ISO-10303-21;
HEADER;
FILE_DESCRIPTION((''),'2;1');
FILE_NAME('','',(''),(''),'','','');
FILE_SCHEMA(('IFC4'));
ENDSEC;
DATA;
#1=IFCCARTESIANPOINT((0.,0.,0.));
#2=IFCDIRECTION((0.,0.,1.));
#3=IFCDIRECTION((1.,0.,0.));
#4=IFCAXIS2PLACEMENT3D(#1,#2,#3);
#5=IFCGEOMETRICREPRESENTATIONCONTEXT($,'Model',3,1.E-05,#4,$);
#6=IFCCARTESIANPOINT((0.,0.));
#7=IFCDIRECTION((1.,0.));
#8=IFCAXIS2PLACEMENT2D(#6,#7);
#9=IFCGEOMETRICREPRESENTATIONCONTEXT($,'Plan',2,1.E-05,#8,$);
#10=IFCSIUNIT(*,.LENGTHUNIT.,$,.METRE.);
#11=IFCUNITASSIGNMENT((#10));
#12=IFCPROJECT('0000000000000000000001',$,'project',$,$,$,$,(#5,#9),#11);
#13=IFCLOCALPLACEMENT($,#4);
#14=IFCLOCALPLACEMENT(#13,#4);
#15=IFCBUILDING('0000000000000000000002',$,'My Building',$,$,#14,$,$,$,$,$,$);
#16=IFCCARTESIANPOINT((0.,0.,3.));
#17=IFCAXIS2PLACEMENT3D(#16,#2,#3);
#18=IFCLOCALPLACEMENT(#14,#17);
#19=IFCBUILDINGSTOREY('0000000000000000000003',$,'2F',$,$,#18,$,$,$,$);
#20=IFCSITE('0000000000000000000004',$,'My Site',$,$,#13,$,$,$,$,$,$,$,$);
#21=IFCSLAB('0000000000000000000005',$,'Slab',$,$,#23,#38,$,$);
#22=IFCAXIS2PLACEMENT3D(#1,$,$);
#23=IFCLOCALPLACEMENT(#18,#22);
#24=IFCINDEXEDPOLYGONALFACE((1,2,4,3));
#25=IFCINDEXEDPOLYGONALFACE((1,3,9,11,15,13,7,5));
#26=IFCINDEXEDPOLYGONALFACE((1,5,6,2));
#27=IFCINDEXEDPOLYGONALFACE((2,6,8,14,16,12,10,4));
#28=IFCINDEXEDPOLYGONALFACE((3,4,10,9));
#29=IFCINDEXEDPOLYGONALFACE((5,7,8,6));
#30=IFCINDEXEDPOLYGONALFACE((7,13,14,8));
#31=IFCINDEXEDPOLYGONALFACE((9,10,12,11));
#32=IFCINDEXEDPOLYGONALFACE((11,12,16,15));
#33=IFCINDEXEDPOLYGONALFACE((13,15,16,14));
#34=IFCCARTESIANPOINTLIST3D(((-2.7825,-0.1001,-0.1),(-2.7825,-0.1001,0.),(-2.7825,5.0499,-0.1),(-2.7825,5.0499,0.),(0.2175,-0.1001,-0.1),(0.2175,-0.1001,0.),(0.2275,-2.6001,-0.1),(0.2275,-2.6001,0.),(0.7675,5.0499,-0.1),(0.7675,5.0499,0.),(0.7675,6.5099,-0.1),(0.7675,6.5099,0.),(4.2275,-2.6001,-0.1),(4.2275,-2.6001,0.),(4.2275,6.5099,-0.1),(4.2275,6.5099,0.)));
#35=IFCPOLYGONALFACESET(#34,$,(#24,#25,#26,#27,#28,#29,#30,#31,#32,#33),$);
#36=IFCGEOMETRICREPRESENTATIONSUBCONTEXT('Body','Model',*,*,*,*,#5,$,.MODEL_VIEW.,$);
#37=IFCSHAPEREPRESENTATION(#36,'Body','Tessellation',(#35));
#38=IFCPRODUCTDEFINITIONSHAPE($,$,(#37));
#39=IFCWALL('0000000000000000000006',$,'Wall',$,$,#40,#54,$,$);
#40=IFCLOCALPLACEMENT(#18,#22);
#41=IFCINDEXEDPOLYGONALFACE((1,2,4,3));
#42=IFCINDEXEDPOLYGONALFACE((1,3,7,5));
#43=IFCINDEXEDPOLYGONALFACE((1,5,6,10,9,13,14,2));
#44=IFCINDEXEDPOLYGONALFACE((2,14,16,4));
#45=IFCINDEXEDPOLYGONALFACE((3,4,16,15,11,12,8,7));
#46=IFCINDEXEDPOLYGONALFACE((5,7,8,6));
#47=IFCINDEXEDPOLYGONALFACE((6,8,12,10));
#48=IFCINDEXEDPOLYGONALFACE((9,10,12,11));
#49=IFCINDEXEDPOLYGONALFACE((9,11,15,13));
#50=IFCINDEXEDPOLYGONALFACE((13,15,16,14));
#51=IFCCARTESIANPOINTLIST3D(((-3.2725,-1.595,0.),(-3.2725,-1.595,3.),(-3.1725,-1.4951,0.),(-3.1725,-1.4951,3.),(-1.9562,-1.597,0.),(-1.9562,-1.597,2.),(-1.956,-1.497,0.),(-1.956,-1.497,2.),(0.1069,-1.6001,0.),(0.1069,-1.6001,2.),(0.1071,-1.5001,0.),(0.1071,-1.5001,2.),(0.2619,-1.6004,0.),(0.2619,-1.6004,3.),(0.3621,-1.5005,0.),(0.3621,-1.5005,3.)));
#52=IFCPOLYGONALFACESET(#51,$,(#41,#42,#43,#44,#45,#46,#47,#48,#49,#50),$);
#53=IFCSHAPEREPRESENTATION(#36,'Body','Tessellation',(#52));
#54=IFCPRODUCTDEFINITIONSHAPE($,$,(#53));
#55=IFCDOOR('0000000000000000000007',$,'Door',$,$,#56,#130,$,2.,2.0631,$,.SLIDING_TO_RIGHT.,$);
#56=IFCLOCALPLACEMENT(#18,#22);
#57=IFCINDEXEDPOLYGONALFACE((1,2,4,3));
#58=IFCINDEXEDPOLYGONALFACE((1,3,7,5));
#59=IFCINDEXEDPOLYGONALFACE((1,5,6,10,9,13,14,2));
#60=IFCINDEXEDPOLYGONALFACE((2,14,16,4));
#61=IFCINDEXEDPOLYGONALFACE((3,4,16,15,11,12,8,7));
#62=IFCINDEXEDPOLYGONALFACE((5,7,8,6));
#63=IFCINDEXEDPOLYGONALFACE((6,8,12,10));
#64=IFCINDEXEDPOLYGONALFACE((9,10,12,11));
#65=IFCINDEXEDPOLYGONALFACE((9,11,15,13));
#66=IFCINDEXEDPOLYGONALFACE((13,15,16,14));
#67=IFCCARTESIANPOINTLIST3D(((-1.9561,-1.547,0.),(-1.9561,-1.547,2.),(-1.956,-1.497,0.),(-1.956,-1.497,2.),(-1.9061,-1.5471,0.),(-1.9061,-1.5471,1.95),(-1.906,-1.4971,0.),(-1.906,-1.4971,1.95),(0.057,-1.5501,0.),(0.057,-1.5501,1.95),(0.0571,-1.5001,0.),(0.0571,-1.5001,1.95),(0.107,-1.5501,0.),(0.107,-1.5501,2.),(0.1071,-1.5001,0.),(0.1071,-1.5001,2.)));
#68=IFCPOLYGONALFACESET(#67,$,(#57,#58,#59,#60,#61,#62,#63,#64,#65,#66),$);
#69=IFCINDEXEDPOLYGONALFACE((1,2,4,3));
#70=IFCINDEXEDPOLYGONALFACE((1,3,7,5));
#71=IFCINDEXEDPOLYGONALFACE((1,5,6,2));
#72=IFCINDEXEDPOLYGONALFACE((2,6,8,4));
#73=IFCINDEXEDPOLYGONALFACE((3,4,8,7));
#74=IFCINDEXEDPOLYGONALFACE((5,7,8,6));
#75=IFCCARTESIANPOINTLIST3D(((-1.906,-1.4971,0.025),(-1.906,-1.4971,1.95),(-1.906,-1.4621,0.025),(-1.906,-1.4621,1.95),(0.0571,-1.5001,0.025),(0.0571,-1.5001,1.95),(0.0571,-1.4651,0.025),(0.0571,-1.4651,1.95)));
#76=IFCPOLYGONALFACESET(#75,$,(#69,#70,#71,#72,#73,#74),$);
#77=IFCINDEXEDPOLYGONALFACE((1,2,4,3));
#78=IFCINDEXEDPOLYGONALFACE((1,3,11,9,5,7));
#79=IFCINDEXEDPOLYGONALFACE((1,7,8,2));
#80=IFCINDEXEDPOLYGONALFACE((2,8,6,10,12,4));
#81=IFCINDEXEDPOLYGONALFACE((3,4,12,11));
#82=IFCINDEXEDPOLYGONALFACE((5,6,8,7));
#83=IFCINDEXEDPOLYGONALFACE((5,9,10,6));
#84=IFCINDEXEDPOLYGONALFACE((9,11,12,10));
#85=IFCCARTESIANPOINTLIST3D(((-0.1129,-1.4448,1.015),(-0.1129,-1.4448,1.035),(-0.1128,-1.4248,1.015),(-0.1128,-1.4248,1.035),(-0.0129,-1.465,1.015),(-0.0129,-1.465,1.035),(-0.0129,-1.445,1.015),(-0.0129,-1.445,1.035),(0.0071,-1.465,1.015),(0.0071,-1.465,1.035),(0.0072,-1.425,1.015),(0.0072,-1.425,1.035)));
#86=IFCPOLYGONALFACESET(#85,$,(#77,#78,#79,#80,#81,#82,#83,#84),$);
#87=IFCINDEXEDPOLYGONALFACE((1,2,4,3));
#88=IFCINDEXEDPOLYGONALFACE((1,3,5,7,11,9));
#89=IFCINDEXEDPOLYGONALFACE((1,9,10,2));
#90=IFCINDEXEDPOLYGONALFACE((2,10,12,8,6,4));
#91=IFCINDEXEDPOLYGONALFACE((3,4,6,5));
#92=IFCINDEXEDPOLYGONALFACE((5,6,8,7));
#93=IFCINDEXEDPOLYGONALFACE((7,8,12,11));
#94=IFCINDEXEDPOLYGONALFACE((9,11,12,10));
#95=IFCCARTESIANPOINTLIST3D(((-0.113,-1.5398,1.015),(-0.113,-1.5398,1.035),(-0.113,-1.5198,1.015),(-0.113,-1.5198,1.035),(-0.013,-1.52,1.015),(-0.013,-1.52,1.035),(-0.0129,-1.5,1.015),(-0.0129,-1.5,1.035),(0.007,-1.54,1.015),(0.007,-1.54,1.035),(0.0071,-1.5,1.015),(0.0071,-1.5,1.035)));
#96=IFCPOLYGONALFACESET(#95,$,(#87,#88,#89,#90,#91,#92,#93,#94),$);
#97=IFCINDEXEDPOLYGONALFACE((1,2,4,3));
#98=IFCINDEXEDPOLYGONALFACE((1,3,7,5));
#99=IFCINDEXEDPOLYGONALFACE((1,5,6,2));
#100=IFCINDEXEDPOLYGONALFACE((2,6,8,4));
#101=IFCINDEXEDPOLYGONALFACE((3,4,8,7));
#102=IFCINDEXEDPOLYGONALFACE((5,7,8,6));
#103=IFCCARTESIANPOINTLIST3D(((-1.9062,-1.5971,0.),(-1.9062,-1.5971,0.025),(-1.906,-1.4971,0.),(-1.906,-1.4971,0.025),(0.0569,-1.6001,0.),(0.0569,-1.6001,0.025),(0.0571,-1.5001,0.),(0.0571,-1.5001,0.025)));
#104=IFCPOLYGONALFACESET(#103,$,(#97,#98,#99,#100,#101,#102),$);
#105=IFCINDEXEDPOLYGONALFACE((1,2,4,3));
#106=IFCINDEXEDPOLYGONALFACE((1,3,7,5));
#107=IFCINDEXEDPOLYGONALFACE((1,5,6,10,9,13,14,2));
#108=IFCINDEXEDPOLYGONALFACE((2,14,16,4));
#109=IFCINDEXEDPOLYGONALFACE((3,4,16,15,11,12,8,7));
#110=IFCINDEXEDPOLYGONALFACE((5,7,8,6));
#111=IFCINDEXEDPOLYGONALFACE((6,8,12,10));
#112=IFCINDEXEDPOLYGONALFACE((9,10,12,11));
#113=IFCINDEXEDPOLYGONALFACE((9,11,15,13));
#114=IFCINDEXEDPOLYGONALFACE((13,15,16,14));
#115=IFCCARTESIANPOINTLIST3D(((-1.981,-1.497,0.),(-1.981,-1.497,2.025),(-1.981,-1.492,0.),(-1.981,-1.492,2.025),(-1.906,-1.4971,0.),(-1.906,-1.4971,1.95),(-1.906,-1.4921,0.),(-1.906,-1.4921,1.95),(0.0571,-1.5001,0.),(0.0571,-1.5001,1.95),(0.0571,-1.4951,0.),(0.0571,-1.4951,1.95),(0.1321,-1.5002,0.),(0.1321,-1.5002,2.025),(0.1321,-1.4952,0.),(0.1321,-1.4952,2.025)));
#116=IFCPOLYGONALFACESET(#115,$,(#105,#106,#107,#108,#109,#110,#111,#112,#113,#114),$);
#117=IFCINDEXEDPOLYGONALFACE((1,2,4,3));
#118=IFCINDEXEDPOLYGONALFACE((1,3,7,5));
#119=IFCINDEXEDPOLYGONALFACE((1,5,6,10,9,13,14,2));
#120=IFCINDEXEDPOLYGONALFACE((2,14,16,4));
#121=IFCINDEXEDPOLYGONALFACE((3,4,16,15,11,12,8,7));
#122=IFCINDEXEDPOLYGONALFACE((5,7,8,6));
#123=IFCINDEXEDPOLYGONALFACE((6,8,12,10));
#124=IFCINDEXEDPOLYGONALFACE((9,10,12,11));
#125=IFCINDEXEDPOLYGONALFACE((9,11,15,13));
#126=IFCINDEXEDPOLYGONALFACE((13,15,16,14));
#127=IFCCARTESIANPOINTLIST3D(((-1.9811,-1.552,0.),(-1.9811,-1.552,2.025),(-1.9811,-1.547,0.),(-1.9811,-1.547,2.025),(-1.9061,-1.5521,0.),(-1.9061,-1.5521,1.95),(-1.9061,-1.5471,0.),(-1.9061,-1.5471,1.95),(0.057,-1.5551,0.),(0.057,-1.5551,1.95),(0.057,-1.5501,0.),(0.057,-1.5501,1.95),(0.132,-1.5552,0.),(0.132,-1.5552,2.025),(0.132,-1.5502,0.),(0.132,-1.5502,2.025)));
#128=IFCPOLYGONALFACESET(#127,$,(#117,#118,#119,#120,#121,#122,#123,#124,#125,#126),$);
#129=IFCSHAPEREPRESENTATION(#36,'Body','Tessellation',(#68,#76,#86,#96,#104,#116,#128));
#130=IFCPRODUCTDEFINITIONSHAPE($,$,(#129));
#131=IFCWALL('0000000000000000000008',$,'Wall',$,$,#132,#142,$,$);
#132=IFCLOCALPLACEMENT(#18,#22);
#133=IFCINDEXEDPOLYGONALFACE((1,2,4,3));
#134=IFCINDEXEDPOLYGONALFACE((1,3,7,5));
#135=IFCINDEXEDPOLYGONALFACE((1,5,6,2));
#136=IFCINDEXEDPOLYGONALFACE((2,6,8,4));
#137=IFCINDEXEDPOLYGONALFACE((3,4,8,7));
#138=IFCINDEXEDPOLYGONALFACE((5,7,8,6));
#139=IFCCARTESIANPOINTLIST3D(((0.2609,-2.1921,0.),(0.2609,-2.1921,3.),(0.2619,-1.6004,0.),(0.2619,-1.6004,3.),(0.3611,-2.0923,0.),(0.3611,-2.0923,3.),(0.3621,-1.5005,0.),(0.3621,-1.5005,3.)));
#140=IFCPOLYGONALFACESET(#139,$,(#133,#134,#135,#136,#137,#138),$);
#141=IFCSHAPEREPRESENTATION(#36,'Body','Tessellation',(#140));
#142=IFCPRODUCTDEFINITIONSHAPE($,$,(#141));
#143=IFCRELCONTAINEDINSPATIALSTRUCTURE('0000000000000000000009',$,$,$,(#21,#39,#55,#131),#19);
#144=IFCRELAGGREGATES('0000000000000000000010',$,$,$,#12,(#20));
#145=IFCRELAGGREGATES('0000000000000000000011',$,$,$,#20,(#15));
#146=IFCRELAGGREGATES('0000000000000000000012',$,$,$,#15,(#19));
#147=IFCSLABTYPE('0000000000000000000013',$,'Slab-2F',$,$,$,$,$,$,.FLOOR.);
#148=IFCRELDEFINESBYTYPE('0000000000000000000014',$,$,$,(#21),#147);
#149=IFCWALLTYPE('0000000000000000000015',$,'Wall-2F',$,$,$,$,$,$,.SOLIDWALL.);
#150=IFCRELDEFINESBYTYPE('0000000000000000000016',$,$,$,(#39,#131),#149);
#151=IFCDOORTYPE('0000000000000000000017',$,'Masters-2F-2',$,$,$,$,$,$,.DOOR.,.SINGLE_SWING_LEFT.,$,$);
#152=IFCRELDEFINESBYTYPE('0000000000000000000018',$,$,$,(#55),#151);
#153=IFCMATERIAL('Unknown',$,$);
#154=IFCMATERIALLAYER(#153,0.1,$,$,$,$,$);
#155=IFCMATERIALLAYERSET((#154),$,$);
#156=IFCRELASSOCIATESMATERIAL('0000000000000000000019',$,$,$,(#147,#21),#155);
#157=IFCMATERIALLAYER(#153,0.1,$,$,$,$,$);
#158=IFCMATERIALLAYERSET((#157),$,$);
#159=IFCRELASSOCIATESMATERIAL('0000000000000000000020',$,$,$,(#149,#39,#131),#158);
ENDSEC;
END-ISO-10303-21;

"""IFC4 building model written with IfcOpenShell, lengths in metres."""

from ifc_helpers import new_model, entity, si_unit, frame, origin_with_axes, origin_2d_with_axis, place, context, subcontext, project, spatial, line, indexed_curve, outline, extrude, shape, source, transform, mapped, material, layer, layer_set, layer_usage, type_object, type_shapes, element, fill, save


model = new_model("IFC4")

# Units and contexts
model_context = context("Model", 3, precision=1e-05, world=origin_with_axes())
plan_context = context("Plan", 2, precision=1e-05, world=origin_2d_with_axis())
body_context_1 = subcontext(model_context, "Body", "Model", "MODEL_VIEW")
body_context_2 = subcontext(plan_context, "Body", "Plan", "PLAN_VIEW")
ifc_project = project(units=[si_unit("LENGTHUNIT", "METRE")], contexts=[model_context, plan_context])

# Site, building, storey
site_placement = place(None, origin_with_axes())
site = spatial("IfcSite", under=ifc_project, at=site_placement, Name="My Site")
building_placement = place(site_placement, origin_with_axes())
building = spatial("IfcBuilding", under=site, at=building_placement, Name="My Building")
storey_placement = place(building_placement, frame((0.0, 0.0, 3.0), z_axis=(0.0, 0.0, 1.0), x_axis=(1.0, 0.0, 0.0)))
storey = spatial("IfcBuildingStorey", under=building, at=storey_placement, Name="2F")

# Slab
ifc_material = material(Name="Unknown")
ifc_layer_1 = layer(ifc_material, 0.1)
ifc_layer_set_1 = layer_set([ifc_layer_1])
ifc_layer_usage_1 = layer_usage(ifc_layer_set_1, "AXIS3", "POSITIVE", -0.1)
slab_type = type_object("IfcSlabType", Name="Slab-2F", PredefinedType="FLOOR", material=ifc_layer_set_1)
slab_placement = place(storey_placement, frame((4.2275, -2.6001, 0.0), z_axis=(0.0, 0.0, 1.0), x_axis=(1.0, 0.0, 0.0)))
element("IfcSlab", 1, at=slab_placement, inside=storey, type_object=slab_type, material=ifc_layer_usage_1, Name="Slab", context=body_context_1, shape_type="SweptSolid", body=[
    extrude(outline(indexed_curve([(0.0, 0.0), (0.0, 9.11), (-3.46, 9.11), (-3.46, 7.65), (-7.01, 7.65), (-7.01, 2.5), (-4.01, 2.5), (-4.0, 0.0), (0.0, 0.0)])), frame((0.0, 0.0, -0.1), z_axis=(0.0, 0.0, 1.0), x_axis=(1.0, 0.0, 0.0)), (0.0, 0.0, 1.0), 0.1),
])

# Wall, opening, door
ifc_layer_2 = layer(ifc_material, 0.1)
ifc_layer_set_2 = layer_set([ifc_layer_2])
ifc_layer_usage_2 = layer_usage(ifc_layer_set_2, "AXIS2", "POSITIVE", 0.0)
wall_type = type_object("IfcWallType", Name="Wall-2F", PredefinedType="SOLIDWALL", material=ifc_layer_set_2)
wall_1_placement = place(storey_placement, frame((-3.2725, -1.595, 0.0), z_axis=(0.0, 0.0, 1.0), x_axis=(0.999999, -0.001525, 0.0)))
wall_1 = element("IfcWall", 2, at=wall_1_placement, inside=storey, type_object=wall_type, material=ifc_layer_usage_2, Name="Wall", context=body_context_1, shape_type="SweptSolid", body=[
    extrude(outline(indexed_curve([(0.0, 0.0), (0.0998, 0.1), (3.6345, 0.1), (3.5345, 0.0)], segments=[line(1, 2, 3, 4, 1)])), origin_with_axes(), (0.0, 0.0, 1.0), 3.0),
])
shared_shape_1 = source(origin_with_axes(), body_context_1, "Body", "SweptSolid", [
    extrude(outline(indexed_curve([(0.0, 0.0), (2.0631, 0.0), (2.0631, 2.0), (0.0, 2.0)], segments=[line(1, 2, 3, 4, 1)])), frame((0.0, -0.6, 0.0), z_axis=(0.0, -1.0, 0.0), x_axis=(1.0, 0.0, 0.0)), (0.0, 0.0, -1.0), 1.2),
])
opening_1_placement = place(wall_1_placement, frame((3.3794, 0.1, 0.0), z_axis=(0.0, 0.0, 1.0), x_axis=(-1.0, 0.0, 0.0)))
opening_1 = element("IfcOpeningElement", 3, at=opening_1_placement, cuts=wall_1, PredefinedType="OPENING", context=body_context_1, shape_type="MappedRepresentation", body=[
    mapped(shared_shape_1, transform((0.0, 0.0, 0.0), x_axis=(1.0, 0.0, 0.0), y_axis=(0.0, 1.0, 0.0), z_axis=(0.0, 0.0, 1.0), scale=1.0)),
])
door_type_1 = type_object("IfcDoorType", Name="Masters-2F-2", OperationType="SINGLE_SWING_LEFT", PredefinedType="DOOR")
shared_shape_2 = source(origin_with_axes(), body_context_1, "Body", "SweptSolid", [
    extrude(outline(indexed_curve([(0.0, 0.0), (0.0, 2.0), (2.0631, 2.0), (2.0631, 0.0), (2.0131, 0.0), (2.0131, 1.95), (0.05, 1.95), (0.05, 0.0)], segments=[line(1, 2, 3, 4, 5, 6, 7, 8, 1)])), frame((0.0, 0.0, 0.0), z_axis=(0.0, -1.0, 0.0), x_axis=(1.0, 0.0, 0.0)), (0.0, 0.0, -1.0), 0.05),
    extrude(outline(indexed_curve([(0.0, 0.0), (1.9631, 0.0), (1.9631, 0.035), (0.0, 0.035)], segments=[line(1, 2, 3, 4, 1)])), frame((0.05, -0.035, 0.025), z_axis=(0.0, 0.0, 1.0), x_axis=(1.0, 0.0, 0.0)), (0.0, 0.0, 1.0), 1.925),
    extrude(outline(indexed_curve([(0.0, 0.0), (0.0, -0.04), (0.12, -0.04), (0.12, -0.02), (0.02, -0.02), (0.02, 0.0)], segments=[line(1, 2, 3, 4, 5, 6, 1)])), frame((0.1, -0.035, 1.015), z_axis=(0.0, 0.0, 1.0), x_axis=(1.0, 0.0, 0.0)), (0.0, 0.0, 1.0), 0.02),
    extrude(outline(indexed_curve([(0.0, 0.0), (0.0, 0.04), (0.12, 0.04), (0.12, 0.02), (0.02, 0.02), (0.02, 0.0)], segments=[line(1, 2, 3, 4, 5, 6, 1)])), frame((0.1, 0.0, 1.015), z_axis=(0.0, 0.0, 1.0), x_axis=(1.0, 0.0, 0.0)), (0.0, 0.0, 1.0), 0.02),
    extrude(outline(indexed_curve([(0.0, 0.0), (1.9631, 0.0), (1.9631, 0.1), (0.0, 0.1)], segments=[line(1, 2, 3, 4, 1)])), frame((0.05, 0.0, 0.0), z_axis=(0.0, 0.0, 1.0), x_axis=(1.0, 0.0, 0.0)), (0.0, 0.0, 1.0), 0.025),
    extrude(outline(indexed_curve([(0.0, 0.0), (0.0, 2.025), (2.1131, 2.025), (2.1131, 0.0), (2.0381, 0.0), (2.0381, 1.95), (0.075, 1.95), (0.075, 0.0)], segments=[line(1, 2, 3, 4, 5, 6, 7, 8, 1)])), frame((-0.025, -0.005, 0.0), z_axis=(0.0, -1.0, 0.0), x_axis=(1.0, 0.0, 0.0)), (0.0, 0.0, -1.0), 0.005),
    extrude(outline(indexed_curve([(0.0, 0.0), (0.0, 2.025), (2.1131, 2.025), (2.1131, 0.0), (2.0381, 0.0), (2.0381, 1.95), (0.075, 1.95), (0.075, 0.0)], segments=[line(1, 2, 3, 4, 5, 6, 7, 8, 1)])), frame((-0.025, 0.05, 0.0), z_axis=(0.0, -1.0, 0.0), x_axis=(1.0, 0.0, 0.0)), (0.0, 0.0, -1.0), 0.005),
])
shared_shape_3 = source(origin_with_axes(), body_context_2, "Body", "Curve2D", [
    entity("IfcIndexedPolyCurve", entity("IfcCartesianPointList2D", [[0.0, 0.0], [0.05, 0.0], [0.05, 0.05], [0.0, 0.05]]), [entity("IfcLineIndex", [1, 2, 3, 4, 1])]),
    entity("IfcIndexedPolyCurve", entity("IfcCartesianPointList2D", [[2.0631, 0.0], [2.0131, 0.0], [2.0131, 0.05], [2.0631, 0.05]]), [entity("IfcLineIndex", [1, 2, 3, 4, 1])]),
    entity("IfcIndexedPolyCurve", entity("IfcCartesianPointList2D", [[2.9946, -0.035], [1.0315, -0.035], [1.0315, 0.0], [2.9946, 0.0]]), [entity("IfcLineIndex", [1, 2, 3, 4, 1])]),
])
type_shapes(door_type_1, [shared_shape_2, shared_shape_3])
door_1_placement = place(opening_1_placement, frame((0.0, 0.0, 0.0), z_axis=(0.0, 0.0, 1.0), x_axis=(1.0, 0.0, 0.0)))
door_1 = element("IfcDoor", 4, at=door_1_placement, inside=storey, type_object=door_type_1, Name="Door", OperationType="SLIDING_TO_RIGHT", OverallHeight=2.0, OverallWidth=2.0631, shapes=[
    shape(body_context_1, "Body", "MappedRepresentation", [mapped(shared_shape_2, transform((0.0, 0.0, 0.0), x_axis=(1.0, 0.0, 0.0), y_axis=(0.0, 1.0, 0.0), z_axis=(0.0, 0.0, 1.0), scale=1.0))]),
    shape(body_context_2, "Body", "MappedRepresentation", [mapped(shared_shape_3, transform((0.0, 0.0, 0.0), x_axis=(1.0, 0.0, 0.0), y_axis=(0.0, 1.0, 0.0), z_axis=(0.0, 0.0, 1.0), scale=1.0))]),
])
fill(opening_1, door_1)

# Wall
ifc_layer_usage_3 = layer_usage(ifc_layer_set_2, "AXIS2", "POSITIVE", 0.0)
wall_2_placement = place(storey_placement, frame((0.2619, -1.6004, 0.0), z_axis=(0.0, 0.0, 1.0), x_axis=(-0.001703, -0.999999, 0.0)))
element("IfcWall", 5, at=wall_2_placement, inside=storey, type_object=wall_type, material=ifc_layer_usage_3, Name="Wall", context=body_context_1, shape_type="SweptSolid", body=[
    extrude(outline(indexed_curve([(0.0, 0.0), (-0.1, 0.1), (0.4917, 0.1), (0.5917, 0.0)], segments=[line(1, 2, 3, 4, 1)])), origin_with_axes(), (0.0, 0.0, 1.0), 3.0),
])

save(model, "model.ifc")
